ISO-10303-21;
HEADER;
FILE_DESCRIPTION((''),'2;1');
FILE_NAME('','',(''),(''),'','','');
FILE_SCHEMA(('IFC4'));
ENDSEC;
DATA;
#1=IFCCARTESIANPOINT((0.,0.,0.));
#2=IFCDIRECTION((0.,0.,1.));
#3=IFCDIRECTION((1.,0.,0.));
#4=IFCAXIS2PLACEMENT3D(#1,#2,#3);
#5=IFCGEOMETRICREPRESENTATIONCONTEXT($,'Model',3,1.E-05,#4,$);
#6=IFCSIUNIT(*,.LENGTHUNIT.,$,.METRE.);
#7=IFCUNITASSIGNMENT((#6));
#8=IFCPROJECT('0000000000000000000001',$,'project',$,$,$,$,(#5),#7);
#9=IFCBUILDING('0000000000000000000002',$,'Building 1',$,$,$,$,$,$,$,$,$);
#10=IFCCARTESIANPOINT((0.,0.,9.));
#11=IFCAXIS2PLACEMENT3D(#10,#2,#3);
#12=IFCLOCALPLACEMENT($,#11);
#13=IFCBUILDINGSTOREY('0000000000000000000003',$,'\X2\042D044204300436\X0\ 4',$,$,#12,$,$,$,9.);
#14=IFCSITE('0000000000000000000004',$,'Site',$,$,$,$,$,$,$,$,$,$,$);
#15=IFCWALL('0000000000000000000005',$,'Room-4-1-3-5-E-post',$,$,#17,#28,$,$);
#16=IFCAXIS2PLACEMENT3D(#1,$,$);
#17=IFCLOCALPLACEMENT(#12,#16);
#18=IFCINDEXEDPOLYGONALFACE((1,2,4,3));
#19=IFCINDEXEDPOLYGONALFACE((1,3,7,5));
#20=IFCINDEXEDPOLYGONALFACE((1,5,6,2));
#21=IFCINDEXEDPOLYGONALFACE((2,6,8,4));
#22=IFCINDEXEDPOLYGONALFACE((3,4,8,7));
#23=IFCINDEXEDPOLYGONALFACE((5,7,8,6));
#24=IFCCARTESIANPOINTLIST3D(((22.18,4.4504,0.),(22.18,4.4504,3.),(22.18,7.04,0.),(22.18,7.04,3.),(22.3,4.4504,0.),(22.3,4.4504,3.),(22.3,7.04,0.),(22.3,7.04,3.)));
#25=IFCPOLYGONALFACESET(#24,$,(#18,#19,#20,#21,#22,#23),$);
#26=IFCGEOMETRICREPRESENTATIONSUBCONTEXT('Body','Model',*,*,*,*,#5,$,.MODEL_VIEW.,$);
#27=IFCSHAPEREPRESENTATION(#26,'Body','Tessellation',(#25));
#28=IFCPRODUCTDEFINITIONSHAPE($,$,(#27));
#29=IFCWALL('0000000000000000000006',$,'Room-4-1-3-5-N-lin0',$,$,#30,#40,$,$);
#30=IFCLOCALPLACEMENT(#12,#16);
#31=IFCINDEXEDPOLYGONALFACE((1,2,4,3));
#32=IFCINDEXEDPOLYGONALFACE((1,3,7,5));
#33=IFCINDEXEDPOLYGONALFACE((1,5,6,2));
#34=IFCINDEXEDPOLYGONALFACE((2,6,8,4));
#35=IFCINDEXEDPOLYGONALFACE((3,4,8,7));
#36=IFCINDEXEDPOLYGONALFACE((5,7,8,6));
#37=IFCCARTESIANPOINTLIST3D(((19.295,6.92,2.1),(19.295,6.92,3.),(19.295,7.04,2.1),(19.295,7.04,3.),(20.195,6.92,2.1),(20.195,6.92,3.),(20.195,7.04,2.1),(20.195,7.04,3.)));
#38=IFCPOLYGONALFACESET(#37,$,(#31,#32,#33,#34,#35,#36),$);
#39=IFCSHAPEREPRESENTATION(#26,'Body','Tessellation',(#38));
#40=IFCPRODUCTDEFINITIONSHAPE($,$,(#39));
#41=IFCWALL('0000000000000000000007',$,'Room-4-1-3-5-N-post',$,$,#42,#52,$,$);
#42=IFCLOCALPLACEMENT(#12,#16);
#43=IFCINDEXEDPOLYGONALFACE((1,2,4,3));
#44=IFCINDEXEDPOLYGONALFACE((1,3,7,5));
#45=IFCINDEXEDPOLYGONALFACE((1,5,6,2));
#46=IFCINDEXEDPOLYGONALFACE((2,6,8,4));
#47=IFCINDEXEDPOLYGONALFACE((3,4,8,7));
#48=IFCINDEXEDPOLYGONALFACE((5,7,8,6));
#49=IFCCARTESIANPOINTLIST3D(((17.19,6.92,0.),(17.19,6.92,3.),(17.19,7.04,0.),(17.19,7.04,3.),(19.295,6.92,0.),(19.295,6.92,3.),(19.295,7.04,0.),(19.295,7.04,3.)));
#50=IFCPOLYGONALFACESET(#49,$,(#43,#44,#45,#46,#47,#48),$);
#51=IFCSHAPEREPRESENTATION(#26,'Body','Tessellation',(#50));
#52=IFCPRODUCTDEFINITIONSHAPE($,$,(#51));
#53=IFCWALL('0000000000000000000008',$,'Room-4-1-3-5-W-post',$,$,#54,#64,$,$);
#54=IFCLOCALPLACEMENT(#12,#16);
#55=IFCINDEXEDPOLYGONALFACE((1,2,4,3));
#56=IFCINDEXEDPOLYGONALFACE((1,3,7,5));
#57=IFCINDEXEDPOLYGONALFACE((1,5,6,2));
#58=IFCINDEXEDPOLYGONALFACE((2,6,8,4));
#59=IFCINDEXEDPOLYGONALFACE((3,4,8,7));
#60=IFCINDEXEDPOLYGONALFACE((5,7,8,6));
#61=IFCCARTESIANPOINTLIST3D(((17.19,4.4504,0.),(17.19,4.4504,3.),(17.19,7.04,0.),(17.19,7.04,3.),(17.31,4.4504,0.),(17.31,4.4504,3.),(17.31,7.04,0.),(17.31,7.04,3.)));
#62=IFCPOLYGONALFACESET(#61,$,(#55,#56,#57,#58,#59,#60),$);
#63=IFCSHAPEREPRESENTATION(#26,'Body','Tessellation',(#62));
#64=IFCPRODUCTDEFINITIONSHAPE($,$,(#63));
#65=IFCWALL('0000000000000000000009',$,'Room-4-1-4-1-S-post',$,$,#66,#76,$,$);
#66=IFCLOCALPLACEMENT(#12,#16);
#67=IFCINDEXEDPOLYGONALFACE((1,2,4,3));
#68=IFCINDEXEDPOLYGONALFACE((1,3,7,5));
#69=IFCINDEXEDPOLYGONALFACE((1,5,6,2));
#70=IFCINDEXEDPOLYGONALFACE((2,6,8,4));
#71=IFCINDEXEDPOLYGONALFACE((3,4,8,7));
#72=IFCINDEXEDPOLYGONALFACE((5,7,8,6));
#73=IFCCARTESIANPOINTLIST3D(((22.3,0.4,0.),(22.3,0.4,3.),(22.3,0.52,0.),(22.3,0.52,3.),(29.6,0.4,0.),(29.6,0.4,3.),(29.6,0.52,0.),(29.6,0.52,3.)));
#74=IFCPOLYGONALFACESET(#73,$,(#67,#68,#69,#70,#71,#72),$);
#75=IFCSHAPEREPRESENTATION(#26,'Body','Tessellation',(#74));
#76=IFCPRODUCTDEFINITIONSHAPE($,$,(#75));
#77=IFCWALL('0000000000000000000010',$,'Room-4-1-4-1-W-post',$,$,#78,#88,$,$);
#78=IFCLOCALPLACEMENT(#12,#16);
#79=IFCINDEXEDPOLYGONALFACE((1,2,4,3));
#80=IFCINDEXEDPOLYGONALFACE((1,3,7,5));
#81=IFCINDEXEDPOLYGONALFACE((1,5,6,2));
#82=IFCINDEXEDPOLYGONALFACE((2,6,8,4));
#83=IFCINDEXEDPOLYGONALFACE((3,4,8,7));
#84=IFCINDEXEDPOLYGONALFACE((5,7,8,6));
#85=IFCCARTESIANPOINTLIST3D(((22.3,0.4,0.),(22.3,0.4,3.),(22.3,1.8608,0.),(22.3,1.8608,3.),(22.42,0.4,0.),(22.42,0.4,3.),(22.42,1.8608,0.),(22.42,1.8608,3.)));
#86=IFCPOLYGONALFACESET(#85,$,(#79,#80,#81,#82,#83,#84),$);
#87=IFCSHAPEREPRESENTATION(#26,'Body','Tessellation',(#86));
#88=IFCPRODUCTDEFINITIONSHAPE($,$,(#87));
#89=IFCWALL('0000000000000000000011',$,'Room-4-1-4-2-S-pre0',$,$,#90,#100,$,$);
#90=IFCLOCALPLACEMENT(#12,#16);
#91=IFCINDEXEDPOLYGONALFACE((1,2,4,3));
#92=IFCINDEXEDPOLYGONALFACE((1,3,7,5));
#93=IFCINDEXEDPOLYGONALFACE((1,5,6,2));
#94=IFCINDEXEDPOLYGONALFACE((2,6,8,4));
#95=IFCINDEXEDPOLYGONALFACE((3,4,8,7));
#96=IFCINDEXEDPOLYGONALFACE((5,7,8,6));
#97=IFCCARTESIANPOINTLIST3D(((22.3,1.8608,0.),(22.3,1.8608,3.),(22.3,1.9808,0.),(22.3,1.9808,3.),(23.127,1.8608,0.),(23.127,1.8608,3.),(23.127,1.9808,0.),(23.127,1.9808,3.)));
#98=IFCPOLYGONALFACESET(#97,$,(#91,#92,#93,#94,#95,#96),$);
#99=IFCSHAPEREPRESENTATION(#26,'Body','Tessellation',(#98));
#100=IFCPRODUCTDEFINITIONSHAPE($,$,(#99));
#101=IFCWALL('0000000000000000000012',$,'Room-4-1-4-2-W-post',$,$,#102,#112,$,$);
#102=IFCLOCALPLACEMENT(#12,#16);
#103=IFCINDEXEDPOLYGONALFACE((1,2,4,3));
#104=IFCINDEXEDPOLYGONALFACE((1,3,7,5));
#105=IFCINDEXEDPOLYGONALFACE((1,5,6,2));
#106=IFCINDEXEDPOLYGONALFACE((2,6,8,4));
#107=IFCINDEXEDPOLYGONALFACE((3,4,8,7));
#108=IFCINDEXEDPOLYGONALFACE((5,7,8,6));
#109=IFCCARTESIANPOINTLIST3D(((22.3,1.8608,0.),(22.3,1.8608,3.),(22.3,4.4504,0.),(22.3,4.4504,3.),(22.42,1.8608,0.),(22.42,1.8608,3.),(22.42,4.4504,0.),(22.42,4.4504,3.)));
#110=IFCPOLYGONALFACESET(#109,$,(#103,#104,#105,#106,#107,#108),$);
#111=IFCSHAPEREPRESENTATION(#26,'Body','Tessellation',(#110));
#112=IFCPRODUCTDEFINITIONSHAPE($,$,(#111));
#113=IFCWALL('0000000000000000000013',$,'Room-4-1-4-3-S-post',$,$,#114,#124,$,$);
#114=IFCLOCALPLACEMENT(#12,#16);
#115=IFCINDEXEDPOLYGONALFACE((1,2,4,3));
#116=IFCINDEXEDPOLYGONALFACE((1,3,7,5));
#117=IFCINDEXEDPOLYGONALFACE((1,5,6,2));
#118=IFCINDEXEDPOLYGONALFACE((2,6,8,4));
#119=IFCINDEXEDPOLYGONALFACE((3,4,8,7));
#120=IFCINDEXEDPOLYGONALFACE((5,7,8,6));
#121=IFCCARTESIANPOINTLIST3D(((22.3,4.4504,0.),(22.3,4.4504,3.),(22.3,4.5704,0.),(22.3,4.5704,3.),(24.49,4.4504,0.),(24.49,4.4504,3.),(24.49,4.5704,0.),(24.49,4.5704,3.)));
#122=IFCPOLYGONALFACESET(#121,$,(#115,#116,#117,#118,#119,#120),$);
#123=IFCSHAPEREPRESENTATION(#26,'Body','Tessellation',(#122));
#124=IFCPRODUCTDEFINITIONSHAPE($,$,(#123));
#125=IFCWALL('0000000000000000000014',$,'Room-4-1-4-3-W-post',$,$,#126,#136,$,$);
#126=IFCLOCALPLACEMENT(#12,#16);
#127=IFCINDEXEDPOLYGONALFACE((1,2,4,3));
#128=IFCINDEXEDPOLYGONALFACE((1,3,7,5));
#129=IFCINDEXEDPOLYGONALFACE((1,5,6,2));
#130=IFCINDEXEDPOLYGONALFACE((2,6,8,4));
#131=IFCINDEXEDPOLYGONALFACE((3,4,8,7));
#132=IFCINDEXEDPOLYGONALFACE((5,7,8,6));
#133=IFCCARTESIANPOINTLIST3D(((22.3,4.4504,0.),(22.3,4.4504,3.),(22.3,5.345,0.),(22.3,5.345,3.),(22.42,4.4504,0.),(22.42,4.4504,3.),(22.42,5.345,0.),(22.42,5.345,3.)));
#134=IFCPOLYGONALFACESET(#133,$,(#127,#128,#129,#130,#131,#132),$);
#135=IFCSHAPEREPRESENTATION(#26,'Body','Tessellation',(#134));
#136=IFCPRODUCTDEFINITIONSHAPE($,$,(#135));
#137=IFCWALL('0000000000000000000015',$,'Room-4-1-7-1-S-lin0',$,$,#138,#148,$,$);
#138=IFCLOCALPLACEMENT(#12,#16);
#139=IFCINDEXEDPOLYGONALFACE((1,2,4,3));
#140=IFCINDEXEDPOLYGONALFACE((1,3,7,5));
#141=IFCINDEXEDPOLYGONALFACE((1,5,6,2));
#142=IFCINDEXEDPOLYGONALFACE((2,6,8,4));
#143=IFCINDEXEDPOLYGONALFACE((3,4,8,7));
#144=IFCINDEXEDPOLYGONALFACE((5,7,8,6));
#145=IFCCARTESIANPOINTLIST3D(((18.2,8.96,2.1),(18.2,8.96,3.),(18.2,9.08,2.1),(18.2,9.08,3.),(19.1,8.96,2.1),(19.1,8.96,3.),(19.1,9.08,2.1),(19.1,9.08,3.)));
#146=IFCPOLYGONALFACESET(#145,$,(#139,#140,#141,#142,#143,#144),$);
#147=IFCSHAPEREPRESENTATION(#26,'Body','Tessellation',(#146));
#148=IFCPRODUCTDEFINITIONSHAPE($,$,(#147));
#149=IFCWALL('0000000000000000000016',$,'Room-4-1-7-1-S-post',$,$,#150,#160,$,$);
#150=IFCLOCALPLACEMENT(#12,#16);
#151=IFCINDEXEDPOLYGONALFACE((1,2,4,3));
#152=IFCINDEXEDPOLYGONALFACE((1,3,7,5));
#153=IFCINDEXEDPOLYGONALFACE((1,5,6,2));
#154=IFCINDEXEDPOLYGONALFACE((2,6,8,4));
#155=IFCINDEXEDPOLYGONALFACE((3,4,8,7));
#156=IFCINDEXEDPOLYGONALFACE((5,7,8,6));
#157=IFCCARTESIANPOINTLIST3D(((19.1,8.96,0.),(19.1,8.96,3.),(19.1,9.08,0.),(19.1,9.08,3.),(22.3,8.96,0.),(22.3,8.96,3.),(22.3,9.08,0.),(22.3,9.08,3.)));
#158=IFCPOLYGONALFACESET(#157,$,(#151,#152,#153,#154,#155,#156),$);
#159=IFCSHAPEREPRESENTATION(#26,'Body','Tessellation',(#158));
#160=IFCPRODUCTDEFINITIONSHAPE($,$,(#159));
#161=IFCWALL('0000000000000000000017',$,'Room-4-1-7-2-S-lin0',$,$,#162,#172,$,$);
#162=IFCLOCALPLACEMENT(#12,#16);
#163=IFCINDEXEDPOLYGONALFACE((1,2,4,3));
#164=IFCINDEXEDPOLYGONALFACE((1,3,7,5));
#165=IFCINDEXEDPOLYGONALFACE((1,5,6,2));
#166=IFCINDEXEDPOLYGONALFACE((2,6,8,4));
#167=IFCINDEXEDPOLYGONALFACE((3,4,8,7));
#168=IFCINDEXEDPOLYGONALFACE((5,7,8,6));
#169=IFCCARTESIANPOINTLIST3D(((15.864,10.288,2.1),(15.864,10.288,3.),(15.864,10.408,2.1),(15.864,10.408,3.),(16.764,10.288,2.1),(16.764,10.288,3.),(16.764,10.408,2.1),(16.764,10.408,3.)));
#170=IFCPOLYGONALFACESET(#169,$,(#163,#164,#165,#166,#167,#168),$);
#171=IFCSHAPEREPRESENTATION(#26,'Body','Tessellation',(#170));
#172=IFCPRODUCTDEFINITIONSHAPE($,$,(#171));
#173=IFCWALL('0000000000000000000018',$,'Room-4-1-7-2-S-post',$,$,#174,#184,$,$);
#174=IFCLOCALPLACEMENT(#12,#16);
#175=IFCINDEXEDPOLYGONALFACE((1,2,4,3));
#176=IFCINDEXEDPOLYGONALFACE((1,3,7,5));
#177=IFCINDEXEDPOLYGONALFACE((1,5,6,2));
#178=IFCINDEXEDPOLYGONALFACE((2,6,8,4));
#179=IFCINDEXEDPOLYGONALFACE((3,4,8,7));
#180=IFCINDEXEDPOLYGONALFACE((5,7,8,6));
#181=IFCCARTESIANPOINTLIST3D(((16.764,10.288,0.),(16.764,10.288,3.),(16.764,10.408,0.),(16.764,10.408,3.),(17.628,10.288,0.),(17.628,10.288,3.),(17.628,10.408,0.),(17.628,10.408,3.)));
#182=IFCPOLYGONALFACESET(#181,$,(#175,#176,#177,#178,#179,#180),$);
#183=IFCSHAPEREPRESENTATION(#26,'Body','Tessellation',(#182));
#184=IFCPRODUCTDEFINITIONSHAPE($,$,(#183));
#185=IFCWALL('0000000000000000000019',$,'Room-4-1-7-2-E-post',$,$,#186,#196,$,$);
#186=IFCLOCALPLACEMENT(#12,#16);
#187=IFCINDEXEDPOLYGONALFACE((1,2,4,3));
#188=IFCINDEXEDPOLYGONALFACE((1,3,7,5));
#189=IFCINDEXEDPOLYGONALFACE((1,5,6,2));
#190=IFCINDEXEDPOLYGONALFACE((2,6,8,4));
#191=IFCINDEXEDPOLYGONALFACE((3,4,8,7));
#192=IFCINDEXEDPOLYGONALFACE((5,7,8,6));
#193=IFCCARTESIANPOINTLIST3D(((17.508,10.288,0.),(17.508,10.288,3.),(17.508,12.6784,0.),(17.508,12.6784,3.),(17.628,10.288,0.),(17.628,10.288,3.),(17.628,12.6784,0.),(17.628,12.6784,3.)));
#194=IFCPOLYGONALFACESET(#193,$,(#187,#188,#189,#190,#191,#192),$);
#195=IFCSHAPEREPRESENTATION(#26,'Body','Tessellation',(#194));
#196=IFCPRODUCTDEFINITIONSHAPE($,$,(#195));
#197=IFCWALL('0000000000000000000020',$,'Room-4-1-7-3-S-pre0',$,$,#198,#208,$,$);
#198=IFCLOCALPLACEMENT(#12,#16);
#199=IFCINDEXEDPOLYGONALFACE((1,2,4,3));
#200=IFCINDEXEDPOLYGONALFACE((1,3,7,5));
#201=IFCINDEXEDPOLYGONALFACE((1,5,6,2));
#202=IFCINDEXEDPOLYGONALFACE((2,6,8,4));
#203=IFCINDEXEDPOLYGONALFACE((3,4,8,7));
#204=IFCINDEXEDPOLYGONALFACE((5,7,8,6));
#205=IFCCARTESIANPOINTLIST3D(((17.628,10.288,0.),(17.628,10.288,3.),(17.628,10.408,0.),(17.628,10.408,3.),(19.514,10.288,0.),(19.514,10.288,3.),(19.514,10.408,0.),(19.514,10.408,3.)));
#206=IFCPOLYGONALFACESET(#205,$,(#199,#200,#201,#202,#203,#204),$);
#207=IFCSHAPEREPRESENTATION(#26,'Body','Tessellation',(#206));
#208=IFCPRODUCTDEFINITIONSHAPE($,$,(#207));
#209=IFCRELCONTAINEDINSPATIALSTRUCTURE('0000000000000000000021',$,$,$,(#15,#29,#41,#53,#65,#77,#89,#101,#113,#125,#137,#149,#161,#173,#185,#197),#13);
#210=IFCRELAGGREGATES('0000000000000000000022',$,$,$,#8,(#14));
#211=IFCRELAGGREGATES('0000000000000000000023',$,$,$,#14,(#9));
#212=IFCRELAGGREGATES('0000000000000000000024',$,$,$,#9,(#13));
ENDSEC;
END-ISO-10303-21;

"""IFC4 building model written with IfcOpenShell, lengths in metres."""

from ifc_helpers import new_model, si_unit, frame, origin_with_axes, place, context, subcontext, project, spatial, indexed_curve, outline, extrude, element, save


model = new_model("IFC4")

# Units and contexts
model_context = context("Model", 3, precision=1e-05, world=origin_with_axes())
body_context = subcontext(model_context, "Body", "Model", "MODEL_VIEW")
ifc_project = project(units=[si_unit("LENGTHUNIT", "METRE")], contexts=[model_context])

# Site, building, storey
site = spatial("IfcSite", under=ifc_project, Name="Site")
building = spatial("IfcBuilding", under=site, Name="Building 1")
storey_placement = place(None, frame((0.0, 0.0, 9.0), z_axis=(0.0, 0.0, 1.0), x_axis=(1.0, 0.0, 0.0)))
storey = spatial("IfcBuildingStorey", under=building, at=storey_placement, Name="Этаж 4", Elevation=9.0)

# Walls
wall_1_placement = place(storey_placement, frame((22.3, 4.4504, 0.0), z_axis=(0.0, 0.0, 1.0), x_axis=(0.0, 1.0, 0.0)))
element("IfcWall", 1, at=wall_1_placement, inside=storey, Name="Room-4-1-3-5-E-post", context=body_context, shape_type="SweptSolid", body=[
    extrude(outline(indexed_curve([(0.0, 0.0), (0.0, 0.12), (2.5896, 0.12), (2.5896, 0.0), (0.0, 0.0)], self_intersect=False)), origin_with_axes(), (0.0, 0.0, 1.0), 3.0),
])
wall_2_placement = place(storey_placement, frame((20.195, 7.04, 2.1), z_axis=(0.0, 0.0, 1.0), x_axis=(-1.0, 0.0, 0.0)))
element("IfcWall", 2, at=wall_2_placement, inside=storey, Name="Room-4-1-3-5-N-lin0", context=body_context, shape_type="SweptSolid", body=[
    extrude(outline(indexed_curve([(0.0, 0.0), (0.0, 0.12), (0.9, 0.12), (0.9, 0.0), (0.0, 0.0)], self_intersect=False)), origin_with_axes(), (0.0, 0.0, 1.0), 0.9),
])
wall_3_placement = place(storey_placement, frame((19.295, 7.04, 0.0), z_axis=(0.0, 0.0, 1.0), x_axis=(-1.0, 0.0, 0.0)))
element("IfcWall", 3, at=wall_3_placement, inside=storey, Name="Room-4-1-3-5-N-post", context=body_context, shape_type="SweptSolid", body=[
    extrude(outline(indexed_curve([(0.0, 0.0), (0.0, 0.12), (2.105, 0.12), (2.105, 0.0), (0.0, 0.0)], self_intersect=False)), origin_with_axes(), (0.0, 0.0, 1.0), 3.0),
])
wall_4_placement = place(storey_placement, frame((17.19, 7.04, 0.0), z_axis=(0.0, 0.0, 1.0), x_axis=(0.0, -1.0, 0.0)))
element("IfcWall", 4, at=wall_4_placement, inside=storey, Name="Room-4-1-3-5-W-post", context=body_context, shape_type="SweptSolid", body=[
    extrude(outline(indexed_curve([(0.0, 0.0), (0.0, 0.12), (2.5896, 0.12), (2.5896, 0.0), (0.0, 0.0)], self_intersect=False)), origin_with_axes(), (0.0, 0.0, 1.0), 3.0),
])
wall_5_placement = place(storey_placement, frame((22.3, 0.4, 0.0), z_axis=(0.0, 0.0, 1.0), x_axis=(1.0, 0.0, 0.0)))
element("IfcWall", 5, at=wall_5_placement, inside=storey, Name="Room-4-1-4-1-S-post", context=body_context, shape_type="SweptSolid", body=[
    extrude(outline(indexed_curve([(0.0, 0.0), (0.0, 0.12), (7.3, 0.12), (7.3, 0.0), (0.0, 0.0)], self_intersect=False)), origin_with_axes(), (0.0, 0.0, 1.0), 3.0),
])
wall_6_placement = place(storey_placement, frame((22.3, 1.8608, 0.0), z_axis=(0.0, 0.0, 1.0), x_axis=(0.0, -1.0, 0.0)))
element("IfcWall", 6, at=wall_6_placement, inside=storey, Name="Room-4-1-4-1-W-post", context=body_context, shape_type="SweptSolid", body=[
    extrude(outline(indexed_curve([(0.0, 0.0), (0.0, 0.12), (1.4608, 0.12), (1.4608, 0.0), (0.0, 0.0)], self_intersect=False)), origin_with_axes(), (0.0, 0.0, 1.0), 3.0),
])
wall_7_placement = place(storey_placement, frame((22.3, 1.8608, 0.0), z_axis=(0.0, 0.0, 1.0), x_axis=(1.0, 0.0, 0.0)))
element("IfcWall", 7, at=wall_7_placement, inside=storey, Name="Room-4-1-4-2-S-pre0", context=body_context, shape_type="SweptSolid", body=[
    extrude(outline(indexed_curve([(0.0, 0.0), (0.0, 0.12), (0.827, 0.12), (0.827, 0.0), (0.0, 0.0)], self_intersect=False)), origin_with_axes(), (0.0, 0.0, 1.0), 3.0),
])
wall_8_placement = place(storey_placement, frame((22.3, 4.4504, 0.0), z_axis=(0.0, 0.0, 1.0), x_axis=(0.0, -1.0, 0.0)))
element("IfcWall", 8, at=wall_8_placement, inside=storey, Name="Room-4-1-4-2-W-post", context=body_context, shape_type="SweptSolid", body=[
    extrude(outline(indexed_curve([(0.0, 0.0), (0.0, 0.12), (2.5896, 0.12), (2.5896, 0.0), (0.0, 0.0)], self_intersect=False)), origin_with_axes(), (0.0, 0.0, 1.0), 3.0),
])
wall_9_placement = place(storey_placement, frame((22.3, 4.4504, 0.0), z_axis=(0.0, 0.0, 1.0), x_axis=(1.0, 0.0, 0.0)))
element("IfcWall", 9, at=wall_9_placement, inside=storey, Name="Room-4-1-4-3-S-post", context=body_context, shape_type="SweptSolid", body=[
    extrude(outline(indexed_curve([(0.0, 0.0), (0.0, 0.12), (2.19, 0.12), (2.19, 0.0), (0.0, 0.0)], self_intersect=False)), origin_with_axes(), (0.0, 0.0, 1.0), 3.0),
])
wall_10_placement = place(storey_placement, frame((22.3, 5.345, 0.0), z_axis=(0.0, 0.0, 1.0), x_axis=(0.0, -1.0, 0.0)))
element("IfcWall", 10, at=wall_10_placement, inside=storey, Name="Room-4-1-4-3-W-post", context=body_context, shape_type="SweptSolid", body=[
    extrude(outline(indexed_curve([(0.0, 0.0), (0.0, 0.12), (0.8946, 0.12), (0.8946, 0.0), (0.0, 0.0)], self_intersect=False)), origin_with_axes(), (0.0, 0.0, 1.0), 3.0),
])
wall_11_placement = place(storey_placement, frame((18.2, 8.96, 2.1), z_axis=(0.0, 0.0, 1.0), x_axis=(1.0, 0.0, 0.0)))
element("IfcWall", 11, at=wall_11_placement, inside=storey, Name="Room-4-1-7-1-S-lin0", context=body_context, shape_type="SweptSolid", body=[
    extrude(outline(indexed_curve([(0.0, 0.0), (0.0, 0.12), (0.9, 0.12), (0.9, 0.0), (0.0, 0.0)], self_intersect=False)), origin_with_axes(), (0.0, 0.0, 1.0), 0.9),
])
wall_12_placement = place(storey_placement, frame((19.1, 8.96, 0.0), z_axis=(0.0, 0.0, 1.0), x_axis=(1.0, 0.0, 0.0)))
element("IfcWall", 12, at=wall_12_placement, inside=storey, Name="Room-4-1-7-1-S-post", context=body_context, shape_type="SweptSolid", body=[
    extrude(outline(indexed_curve([(0.0, 0.0), (0.0, 0.12), (3.2, 0.12), (3.2, 0.0), (0.0, 0.0)], self_intersect=False)), origin_with_axes(), (0.0, 0.0, 1.0), 3.0),
])
wall_13_placement = place(storey_placement, frame((15.864, 10.288, 2.1), z_axis=(0.0, 0.0, 1.0), x_axis=(1.0, 0.0, 0.0)))
element("IfcWall", 13, at=wall_13_placement, inside=storey, Name="Room-4-1-7-2-S-lin0", context=body_context, shape_type="SweptSolid", body=[
    extrude(outline(indexed_curve([(0.0, 0.0), (0.0, 0.12), (0.9, 0.12), (0.9, 0.0), (0.0, 0.0)], self_intersect=False)), origin_with_axes(), (0.0, 0.0, 1.0), 0.9),
])
wall_14_placement = place(storey_placement, frame((16.764, 10.288, 0.0), z_axis=(0.0, 0.0, 1.0), x_axis=(1.0, 0.0, 0.0)))
element("IfcWall", 14, at=wall_14_placement, inside=storey, Name="Room-4-1-7-2-S-post", context=body_context, shape_type="SweptSolid", body=[
    extrude(outline(indexed_curve([(0.0, 0.0), (0.0, 0.12), (0.864, 0.12), (0.864, 0.0), (0.0, 0.0)], self_intersect=False)), origin_with_axes(), (0.0, 0.0, 1.0), 3.0),
])
wall_15_placement = place(storey_placement, frame((17.628, 10.288, 0.0), z_axis=(0.0, 0.0, 1.0), x_axis=(0.0, 1.0, 0.0)))
element("IfcWall", 15, at=wall_15_placement, inside=storey, Name="Room-4-1-7-2-E-post", context=body_context, shape_type="SweptSolid", body=[
    extrude(outline(indexed_curve([(0.0, 0.0), (0.0, 0.12), (2.3904, 0.12), (2.3904, 0.0), (0.0, 0.0)], self_intersect=False)), origin_with_axes(), (0.0, 0.0, 1.0), 3.0),
])
wall_16_placement = place(storey_placement, frame((17.628, 10.288, 0.0), z_axis=(0.0, 0.0, 1.0), x_axis=(1.0, 0.0, 0.0)))
element("IfcWall", 16, at=wall_16_placement, inside=storey, Name="Room-4-1-7-3-S-pre0", context=body_context, shape_type="SweptSolid", body=[
    extrude(outline(indexed_curve([(0.0, 0.0), (0.0, 0.12), (1.886, 0.12), (1.886, 0.0), (0.0, 0.0)], self_intersect=False)), origin_with_axes(), (0.0, 0.0, 1.0), 3.0),
])

save(model, "model.ifc")
